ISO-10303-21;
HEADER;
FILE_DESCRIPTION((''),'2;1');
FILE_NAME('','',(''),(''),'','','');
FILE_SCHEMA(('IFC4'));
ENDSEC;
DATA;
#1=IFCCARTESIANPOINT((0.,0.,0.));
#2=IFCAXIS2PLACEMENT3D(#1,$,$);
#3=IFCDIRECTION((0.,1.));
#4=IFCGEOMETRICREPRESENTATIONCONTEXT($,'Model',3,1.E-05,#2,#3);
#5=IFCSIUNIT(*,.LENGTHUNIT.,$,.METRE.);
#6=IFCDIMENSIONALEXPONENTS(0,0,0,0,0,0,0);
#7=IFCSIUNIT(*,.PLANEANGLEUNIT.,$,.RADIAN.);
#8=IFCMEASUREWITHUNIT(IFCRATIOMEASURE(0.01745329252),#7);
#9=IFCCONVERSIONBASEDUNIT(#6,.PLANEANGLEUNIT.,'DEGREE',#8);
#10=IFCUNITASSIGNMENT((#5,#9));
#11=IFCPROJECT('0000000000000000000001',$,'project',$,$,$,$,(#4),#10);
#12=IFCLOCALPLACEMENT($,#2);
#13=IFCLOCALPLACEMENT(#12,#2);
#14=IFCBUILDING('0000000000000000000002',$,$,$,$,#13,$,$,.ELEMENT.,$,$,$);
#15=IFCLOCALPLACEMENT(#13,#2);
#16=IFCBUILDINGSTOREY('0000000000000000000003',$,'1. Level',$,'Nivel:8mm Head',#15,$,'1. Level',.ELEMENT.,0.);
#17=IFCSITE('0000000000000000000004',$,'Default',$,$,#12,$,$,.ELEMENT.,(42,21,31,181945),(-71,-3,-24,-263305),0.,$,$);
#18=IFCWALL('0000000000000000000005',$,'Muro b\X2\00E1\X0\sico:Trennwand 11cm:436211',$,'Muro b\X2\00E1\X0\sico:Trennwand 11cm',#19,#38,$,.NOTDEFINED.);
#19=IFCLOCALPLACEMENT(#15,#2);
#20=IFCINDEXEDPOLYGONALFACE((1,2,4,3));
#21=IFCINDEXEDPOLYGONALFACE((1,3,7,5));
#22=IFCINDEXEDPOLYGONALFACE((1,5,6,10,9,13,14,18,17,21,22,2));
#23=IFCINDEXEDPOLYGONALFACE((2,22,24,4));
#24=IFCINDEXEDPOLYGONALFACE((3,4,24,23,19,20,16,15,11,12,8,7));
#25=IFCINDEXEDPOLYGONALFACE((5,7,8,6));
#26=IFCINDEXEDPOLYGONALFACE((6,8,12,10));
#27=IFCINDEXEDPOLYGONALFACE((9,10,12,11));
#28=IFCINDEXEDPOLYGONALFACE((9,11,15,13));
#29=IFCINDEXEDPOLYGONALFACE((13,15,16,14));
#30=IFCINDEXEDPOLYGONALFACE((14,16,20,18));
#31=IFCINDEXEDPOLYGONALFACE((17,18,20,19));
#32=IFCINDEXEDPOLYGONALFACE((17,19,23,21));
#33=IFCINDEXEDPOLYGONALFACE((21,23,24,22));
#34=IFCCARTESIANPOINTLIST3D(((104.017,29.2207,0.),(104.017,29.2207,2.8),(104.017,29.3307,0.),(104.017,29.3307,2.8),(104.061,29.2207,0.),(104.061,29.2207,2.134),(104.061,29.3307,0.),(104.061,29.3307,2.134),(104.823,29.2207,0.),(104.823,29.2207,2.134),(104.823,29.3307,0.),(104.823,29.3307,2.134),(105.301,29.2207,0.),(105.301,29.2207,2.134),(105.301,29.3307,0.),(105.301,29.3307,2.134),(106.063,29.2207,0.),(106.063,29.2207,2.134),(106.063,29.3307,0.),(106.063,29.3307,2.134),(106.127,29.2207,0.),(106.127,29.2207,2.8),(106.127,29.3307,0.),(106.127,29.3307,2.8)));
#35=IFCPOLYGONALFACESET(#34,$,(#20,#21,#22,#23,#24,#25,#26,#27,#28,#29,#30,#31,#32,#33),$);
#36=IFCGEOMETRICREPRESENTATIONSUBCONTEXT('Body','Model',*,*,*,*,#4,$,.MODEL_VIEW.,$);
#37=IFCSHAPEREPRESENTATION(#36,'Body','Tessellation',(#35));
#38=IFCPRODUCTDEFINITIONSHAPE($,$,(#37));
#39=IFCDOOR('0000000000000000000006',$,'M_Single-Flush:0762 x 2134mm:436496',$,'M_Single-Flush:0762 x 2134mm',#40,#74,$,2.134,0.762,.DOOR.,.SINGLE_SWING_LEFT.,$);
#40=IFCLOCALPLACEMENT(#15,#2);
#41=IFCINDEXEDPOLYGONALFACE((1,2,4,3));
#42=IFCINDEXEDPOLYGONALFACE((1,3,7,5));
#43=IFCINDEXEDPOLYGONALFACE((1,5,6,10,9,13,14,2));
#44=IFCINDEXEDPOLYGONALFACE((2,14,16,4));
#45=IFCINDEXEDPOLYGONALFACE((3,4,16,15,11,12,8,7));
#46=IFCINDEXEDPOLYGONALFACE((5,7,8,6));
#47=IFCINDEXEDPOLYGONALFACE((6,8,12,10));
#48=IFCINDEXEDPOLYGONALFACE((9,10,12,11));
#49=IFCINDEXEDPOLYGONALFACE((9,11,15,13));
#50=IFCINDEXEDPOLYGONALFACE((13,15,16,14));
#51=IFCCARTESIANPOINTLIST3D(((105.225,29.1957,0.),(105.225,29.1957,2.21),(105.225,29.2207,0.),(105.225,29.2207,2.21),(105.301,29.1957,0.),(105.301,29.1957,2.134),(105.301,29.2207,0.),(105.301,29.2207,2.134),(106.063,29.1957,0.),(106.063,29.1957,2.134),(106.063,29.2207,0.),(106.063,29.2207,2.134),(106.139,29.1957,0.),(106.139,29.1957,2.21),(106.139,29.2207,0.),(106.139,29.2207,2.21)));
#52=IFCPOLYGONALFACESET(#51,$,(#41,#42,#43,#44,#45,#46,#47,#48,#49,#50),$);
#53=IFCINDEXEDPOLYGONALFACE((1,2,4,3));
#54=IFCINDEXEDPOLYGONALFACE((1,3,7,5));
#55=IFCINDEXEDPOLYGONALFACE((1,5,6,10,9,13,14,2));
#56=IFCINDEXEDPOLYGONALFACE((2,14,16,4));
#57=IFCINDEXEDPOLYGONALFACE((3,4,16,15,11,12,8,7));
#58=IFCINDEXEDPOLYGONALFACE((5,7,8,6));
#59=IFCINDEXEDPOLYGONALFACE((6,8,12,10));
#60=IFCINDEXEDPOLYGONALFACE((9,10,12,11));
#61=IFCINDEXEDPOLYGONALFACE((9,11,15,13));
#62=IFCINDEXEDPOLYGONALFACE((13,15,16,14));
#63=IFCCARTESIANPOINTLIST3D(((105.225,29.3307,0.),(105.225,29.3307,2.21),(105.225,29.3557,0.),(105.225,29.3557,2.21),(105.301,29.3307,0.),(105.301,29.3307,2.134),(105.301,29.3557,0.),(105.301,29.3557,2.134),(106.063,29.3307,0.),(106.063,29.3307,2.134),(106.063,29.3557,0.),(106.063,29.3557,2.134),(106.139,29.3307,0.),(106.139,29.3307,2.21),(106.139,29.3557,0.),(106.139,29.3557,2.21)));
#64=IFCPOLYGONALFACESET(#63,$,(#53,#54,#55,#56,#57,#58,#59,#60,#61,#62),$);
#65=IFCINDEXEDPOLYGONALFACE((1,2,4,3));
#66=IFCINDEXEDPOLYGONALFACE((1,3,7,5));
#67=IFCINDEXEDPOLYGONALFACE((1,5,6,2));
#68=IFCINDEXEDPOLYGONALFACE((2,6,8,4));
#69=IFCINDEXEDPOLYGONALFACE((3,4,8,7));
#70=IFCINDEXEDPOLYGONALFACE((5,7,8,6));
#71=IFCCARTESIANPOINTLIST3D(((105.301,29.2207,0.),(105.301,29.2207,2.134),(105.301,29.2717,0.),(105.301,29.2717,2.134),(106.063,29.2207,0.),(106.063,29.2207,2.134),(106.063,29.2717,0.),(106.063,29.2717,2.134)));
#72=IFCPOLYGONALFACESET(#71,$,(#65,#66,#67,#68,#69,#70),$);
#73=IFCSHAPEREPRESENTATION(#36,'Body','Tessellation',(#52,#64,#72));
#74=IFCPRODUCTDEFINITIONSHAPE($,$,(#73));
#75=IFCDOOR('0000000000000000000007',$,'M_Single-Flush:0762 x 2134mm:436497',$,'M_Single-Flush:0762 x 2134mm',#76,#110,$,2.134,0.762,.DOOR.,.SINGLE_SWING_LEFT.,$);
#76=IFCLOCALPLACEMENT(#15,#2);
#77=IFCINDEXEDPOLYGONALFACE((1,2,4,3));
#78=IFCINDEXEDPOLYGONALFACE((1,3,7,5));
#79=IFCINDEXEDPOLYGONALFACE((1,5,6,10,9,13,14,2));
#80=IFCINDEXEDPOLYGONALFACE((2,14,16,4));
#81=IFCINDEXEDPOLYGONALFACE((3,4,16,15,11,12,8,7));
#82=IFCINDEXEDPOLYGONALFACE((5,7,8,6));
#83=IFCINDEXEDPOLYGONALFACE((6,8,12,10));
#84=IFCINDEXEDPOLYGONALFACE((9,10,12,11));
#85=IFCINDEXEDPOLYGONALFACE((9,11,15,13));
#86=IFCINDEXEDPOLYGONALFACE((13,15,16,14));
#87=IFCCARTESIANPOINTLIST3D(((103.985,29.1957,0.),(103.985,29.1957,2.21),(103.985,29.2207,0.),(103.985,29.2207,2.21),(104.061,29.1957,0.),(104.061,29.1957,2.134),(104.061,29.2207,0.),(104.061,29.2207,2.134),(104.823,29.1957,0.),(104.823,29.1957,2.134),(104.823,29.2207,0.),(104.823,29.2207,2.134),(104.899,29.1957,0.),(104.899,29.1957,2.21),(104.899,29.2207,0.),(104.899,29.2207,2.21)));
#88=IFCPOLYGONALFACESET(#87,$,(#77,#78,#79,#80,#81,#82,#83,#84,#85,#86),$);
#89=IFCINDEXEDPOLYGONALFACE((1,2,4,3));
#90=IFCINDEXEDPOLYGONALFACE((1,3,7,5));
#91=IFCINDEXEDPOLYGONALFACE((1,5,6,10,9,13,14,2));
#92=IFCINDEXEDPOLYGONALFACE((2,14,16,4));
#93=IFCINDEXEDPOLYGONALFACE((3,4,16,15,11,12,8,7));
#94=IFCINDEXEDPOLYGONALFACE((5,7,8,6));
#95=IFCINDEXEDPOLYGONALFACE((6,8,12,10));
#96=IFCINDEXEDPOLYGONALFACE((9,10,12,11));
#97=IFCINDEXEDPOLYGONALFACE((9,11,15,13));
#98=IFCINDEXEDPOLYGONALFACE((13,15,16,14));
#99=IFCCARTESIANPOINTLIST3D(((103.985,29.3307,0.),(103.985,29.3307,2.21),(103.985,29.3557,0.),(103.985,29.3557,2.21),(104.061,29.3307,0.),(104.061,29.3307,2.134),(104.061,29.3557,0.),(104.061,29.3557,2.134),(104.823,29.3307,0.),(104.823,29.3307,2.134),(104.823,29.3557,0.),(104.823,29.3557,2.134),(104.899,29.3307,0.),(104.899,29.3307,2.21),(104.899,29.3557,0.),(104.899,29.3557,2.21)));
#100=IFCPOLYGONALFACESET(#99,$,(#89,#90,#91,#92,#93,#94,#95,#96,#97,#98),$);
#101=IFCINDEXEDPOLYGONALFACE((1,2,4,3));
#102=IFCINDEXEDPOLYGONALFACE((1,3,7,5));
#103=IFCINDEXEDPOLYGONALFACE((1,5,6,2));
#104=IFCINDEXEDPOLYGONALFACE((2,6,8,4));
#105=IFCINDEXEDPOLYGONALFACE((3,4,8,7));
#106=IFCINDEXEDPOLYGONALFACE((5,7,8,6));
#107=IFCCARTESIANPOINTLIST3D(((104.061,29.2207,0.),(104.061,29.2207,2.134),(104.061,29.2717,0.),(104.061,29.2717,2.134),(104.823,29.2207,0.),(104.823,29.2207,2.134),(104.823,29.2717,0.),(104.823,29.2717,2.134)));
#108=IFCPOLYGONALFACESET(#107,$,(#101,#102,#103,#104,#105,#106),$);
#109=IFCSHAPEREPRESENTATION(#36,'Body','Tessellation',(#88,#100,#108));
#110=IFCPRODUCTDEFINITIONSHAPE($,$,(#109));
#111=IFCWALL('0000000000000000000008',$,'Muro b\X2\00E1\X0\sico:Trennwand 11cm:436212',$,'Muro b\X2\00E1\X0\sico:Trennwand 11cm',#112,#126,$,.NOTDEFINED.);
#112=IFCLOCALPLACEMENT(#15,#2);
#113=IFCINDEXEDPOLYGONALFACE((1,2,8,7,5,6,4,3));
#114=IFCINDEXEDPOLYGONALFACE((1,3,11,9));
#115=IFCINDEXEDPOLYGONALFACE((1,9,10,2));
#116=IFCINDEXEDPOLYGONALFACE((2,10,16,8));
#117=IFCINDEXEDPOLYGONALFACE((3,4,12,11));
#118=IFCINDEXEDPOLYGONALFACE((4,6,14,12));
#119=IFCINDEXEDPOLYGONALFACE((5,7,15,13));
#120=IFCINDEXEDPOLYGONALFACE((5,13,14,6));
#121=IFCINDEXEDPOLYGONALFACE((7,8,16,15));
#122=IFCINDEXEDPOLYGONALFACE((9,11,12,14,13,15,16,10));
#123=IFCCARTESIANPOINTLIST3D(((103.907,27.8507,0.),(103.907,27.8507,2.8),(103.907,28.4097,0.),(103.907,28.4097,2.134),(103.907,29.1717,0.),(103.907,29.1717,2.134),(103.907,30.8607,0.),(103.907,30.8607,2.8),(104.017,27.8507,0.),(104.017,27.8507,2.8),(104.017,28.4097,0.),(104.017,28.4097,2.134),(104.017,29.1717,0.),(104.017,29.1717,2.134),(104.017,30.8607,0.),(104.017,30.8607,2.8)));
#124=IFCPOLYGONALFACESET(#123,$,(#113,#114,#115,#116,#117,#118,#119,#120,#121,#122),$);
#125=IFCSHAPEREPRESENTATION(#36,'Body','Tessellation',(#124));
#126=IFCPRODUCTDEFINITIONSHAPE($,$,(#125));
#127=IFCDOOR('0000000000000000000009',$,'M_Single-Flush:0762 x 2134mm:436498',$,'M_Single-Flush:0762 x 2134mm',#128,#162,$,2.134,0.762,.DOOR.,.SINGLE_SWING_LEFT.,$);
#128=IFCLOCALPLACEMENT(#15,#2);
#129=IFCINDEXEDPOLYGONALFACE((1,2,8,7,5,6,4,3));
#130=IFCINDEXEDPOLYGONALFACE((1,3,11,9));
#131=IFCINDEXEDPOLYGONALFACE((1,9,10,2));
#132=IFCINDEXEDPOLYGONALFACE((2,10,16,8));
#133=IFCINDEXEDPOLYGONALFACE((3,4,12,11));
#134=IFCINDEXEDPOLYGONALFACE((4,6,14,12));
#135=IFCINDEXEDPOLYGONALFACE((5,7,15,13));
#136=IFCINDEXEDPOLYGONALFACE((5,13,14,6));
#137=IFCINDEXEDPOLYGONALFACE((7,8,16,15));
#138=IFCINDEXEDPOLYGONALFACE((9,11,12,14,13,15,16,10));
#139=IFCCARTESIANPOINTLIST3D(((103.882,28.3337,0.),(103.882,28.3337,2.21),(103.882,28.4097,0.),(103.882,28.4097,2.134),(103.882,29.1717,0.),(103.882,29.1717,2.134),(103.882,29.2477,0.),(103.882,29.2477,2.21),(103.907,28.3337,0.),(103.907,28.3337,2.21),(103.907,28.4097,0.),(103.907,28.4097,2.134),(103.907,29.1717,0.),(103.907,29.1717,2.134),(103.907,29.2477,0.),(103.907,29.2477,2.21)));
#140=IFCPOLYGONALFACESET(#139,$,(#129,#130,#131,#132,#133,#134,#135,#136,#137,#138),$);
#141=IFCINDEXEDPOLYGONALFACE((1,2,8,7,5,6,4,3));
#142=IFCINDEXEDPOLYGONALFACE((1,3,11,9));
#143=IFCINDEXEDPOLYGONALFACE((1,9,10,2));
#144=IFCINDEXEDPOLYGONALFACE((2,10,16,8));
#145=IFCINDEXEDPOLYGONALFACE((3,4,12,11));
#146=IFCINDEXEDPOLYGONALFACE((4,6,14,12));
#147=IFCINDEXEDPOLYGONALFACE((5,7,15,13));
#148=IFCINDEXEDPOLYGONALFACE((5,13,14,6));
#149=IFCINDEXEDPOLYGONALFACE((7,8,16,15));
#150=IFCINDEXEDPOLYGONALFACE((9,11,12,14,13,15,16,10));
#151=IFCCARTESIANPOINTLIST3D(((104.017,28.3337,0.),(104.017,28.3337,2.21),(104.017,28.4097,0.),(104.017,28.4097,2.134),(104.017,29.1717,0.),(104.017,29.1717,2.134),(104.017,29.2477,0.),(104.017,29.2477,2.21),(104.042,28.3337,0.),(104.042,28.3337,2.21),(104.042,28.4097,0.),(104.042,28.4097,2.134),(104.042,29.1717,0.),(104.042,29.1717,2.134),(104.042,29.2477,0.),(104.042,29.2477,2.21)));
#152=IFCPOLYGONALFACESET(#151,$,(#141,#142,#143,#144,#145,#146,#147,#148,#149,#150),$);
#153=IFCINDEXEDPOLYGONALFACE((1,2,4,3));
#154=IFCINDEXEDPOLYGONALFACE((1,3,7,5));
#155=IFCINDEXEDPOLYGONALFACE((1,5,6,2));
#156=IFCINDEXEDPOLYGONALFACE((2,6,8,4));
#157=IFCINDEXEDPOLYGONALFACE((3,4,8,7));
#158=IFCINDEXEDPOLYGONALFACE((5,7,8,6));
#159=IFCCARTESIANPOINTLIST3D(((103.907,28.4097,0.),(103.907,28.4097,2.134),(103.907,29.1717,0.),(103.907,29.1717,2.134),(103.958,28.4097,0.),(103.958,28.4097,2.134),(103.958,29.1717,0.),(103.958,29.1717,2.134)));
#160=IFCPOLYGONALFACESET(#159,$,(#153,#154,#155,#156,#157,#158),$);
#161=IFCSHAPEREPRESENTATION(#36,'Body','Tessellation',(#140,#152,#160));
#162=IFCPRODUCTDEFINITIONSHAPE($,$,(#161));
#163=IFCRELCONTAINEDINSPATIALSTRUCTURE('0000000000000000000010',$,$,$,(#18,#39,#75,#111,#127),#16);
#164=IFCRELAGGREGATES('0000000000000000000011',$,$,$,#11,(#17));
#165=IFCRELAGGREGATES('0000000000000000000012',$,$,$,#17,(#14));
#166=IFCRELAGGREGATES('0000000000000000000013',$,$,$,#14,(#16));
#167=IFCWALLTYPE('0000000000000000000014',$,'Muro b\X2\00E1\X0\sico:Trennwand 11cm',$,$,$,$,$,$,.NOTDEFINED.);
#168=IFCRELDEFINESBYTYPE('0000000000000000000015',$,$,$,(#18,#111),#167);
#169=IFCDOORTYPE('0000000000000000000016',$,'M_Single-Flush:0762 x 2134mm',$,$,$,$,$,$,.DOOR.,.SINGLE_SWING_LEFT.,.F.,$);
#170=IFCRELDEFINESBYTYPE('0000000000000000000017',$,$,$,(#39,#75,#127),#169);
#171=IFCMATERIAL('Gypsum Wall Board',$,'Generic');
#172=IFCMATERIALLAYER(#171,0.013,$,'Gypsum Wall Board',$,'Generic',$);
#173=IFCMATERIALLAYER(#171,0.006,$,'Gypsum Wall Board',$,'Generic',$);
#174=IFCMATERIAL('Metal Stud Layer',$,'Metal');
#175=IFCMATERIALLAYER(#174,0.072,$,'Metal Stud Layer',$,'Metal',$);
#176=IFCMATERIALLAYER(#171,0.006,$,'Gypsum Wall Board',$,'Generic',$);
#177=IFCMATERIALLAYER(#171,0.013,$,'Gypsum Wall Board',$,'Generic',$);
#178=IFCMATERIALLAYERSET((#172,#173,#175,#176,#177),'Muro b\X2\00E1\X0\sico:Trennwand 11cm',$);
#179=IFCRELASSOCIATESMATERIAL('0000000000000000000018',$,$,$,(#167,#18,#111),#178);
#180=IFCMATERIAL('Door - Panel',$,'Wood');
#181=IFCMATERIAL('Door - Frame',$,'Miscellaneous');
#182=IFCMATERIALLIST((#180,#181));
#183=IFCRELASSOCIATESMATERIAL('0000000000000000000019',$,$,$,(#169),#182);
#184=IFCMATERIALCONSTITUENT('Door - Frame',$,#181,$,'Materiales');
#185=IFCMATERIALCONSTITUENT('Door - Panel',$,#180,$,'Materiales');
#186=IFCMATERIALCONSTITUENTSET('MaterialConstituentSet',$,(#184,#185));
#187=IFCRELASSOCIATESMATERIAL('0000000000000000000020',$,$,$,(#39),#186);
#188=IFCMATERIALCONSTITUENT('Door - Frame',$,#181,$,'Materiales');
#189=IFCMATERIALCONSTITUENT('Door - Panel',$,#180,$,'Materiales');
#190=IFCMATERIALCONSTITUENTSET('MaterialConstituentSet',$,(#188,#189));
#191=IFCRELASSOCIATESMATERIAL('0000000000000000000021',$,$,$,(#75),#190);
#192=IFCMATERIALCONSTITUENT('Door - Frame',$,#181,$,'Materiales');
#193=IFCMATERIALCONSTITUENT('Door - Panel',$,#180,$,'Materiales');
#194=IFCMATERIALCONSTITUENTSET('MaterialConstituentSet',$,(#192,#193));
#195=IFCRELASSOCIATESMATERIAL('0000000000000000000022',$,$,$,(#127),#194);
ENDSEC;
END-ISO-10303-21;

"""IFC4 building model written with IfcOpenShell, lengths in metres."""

from ifc_helpers import new_model, entity, si_unit, converted_unit, direction, frame, frame_2d, origin, origin_2d_with_axis, place, context, subcontext, project, spatial, polyline, rectangle, outline, extrude, source, transform, mapped, material, material_list, layer, layer_set, layer_usage, constituent, constituent_set, type_object, type_shapes, element, fill, save


model = new_model("IFC4")

# Units and contexts
model_context = context("Model", 3, precision=1e-05, world=origin(), true_north=direction((0.0, 1.0)))
body_context = subcontext(model_context, "Body", "Model", "MODEL_VIEW")
ifc_project = project(units=[si_unit("LENGTHUNIT", "METRE"), converted_unit("PLANEANGLEUNIT", "DEGREE", entity("IfcRatioMeasure", 0.01745329252), si_unit("PLANEANGLEUNIT", "RADIAN"), dimensions=[0, 0, 0, 0, 0, 0, 0])], contexts=[model_context])

# Site, building, storey
site_placement = place(None, origin())
site = spatial("IfcSite", under=ifc_project, at=site_placement, Name="Default", CompositionType="ELEMENT", RefLatitude=(42, 21, 31, 181945), RefLongitude=(-71, -3, -24, -263305), RefElevation=0.0)
building_placement = place(site_placement, origin())
building = spatial("IfcBuilding", under=site, at=building_placement, CompositionType="ELEMENT")
storey_placement = place(building_placement, origin())
storey = spatial("IfcBuildingStorey", under=building, at=storey_placement, Name="1. Level", ObjectType="Nivel:8mm Head", LongName="1. Level", CompositionType="ELEMENT", Elevation=0.0)

# Shared definitions
ifc_material_1 = material(Name="Gypsum Wall Board", Category="Generic")
ifc_layer_1 = layer(ifc_material_1, 0.013, Name="Gypsum Wall Board", Category="Generic")
ifc_layer_2 = layer(ifc_material_1, 0.006, Name="Gypsum Wall Board", Category="Generic")
ifc_material_2 = material(Name="Metal Stud Layer", Category="Metal")
ifc_layer_3 = layer(ifc_material_2, 0.072, Name="Metal Stud Layer", Category="Metal")
ifc_layer_4 = layer(ifc_material_1, 0.006, Name="Gypsum Wall Board", Category="Generic")
ifc_layer_5 = layer(ifc_material_1, 0.013, Name="Gypsum Wall Board", Category="Generic")
ifc_layer_set_1 = layer_set([ifc_layer_1, ifc_layer_2, ifc_layer_3, ifc_layer_4, ifc_layer_5], Name="Muro básico:Trennwand 11cm")
wall_type_1 = type_object("IfcWallType", Name="Muro básico:Trennwand 11cm", PredefinedType="NOTDEFINED", material=ifc_layer_set_1)
ifc_material_3 = material(Name="Door - Frame", Category="Miscellaneous")
ifc_material_4 = material(Name="Door - Panel", Category="Wood")
ifc_material_list_1 = material_list([ifc_material_4, ifc_material_3])
door_type_1 = type_object("IfcDoorType", Name="M_Single-Flush:0762 x 2134mm", OperationType="SINGLE_SWING_LEFT", ParameterTakesPrecedence=False, PredefinedType="DOOR", material=ifc_material_list_1)
shared_shape_1 = source(origin(), body_context, "Body", "SweptSolid", [
    extrude(outline(polyline([(-0.457, -1.124), (0.457, -1.124), (0.457, 1.086), (0.381, 1.086), (0.381, -1.048), (-0.381, -1.048), (-0.381, 1.086), (-0.457, 1.086), (-0.457, -1.124)])), frame((0.381, 0.135, 1.086), z_axis=(0.0, -1.0, 0.0), x_axis=(-1.0, 0.0, 0.0)), (0.0, 0.0, 1.0), 0.025),
    extrude(outline(polyline([(-1.124, -0.457), (1.086, -0.457), (1.086, -0.381), (-1.048, -0.381), (-1.048, 0.381), (1.086, 0.381), (1.086, 0.457), (-1.124, 0.457), (-1.124, -0.457)])), frame((0.381, 0.0, 1.086), z_axis=(0.0, -1.0, 0.0), x_axis=(0.0, 0.0, -1.0)), (0.0, 0.0, 1.0), 0.025),
    extrude(rectangle(XDim=0.762, YDim=0.051, at=origin_2d_with_axis()), frame((0.381, 0.0845, 0.0)), (0.0, 0.0, 1.0), 2.134),
])
type_shapes(door_type_1, [shared_shape_1])

# Wall, openings, doors
ifc_layer_usage_1 = layer_usage(ifc_layer_set_1, "AXIS2", "NEGATIVE", 0.055)
wall_1_placement = place(storey_placement, frame((106.127, 29.2757, 0.0), z_axis=(0.0, 0.0, 1.0), x_axis=(-1.0, 0.0, 0.0)))
wall_1 = element("IfcWall", 1, at=wall_1_placement, inside=storey, type_object=wall_type_1, material=ifc_layer_usage_1, Name="Muro básico:Trennwand 11cm:436211", ObjectType="Muro básico:Trennwand 11cm", PredefinedType="NOTDEFINED", context=body_context, shape_type="SweptSolid", body=[
    extrude(rectangle(XDim=2.11, YDim=0.11, at=frame_2d((1.055, 0.0), x_axis=(-1.0, 0.0))), origin(), (0.0, 0.0, 1.0), 2.8),
])
opening_1_placement = place(wall_1_placement, frame((0.064, -0.055, 0.0)))
opening_1 = element("IfcOpeningElement", 2, at=opening_1_placement, cuts=wall_1, ObjectType="Opening", PredefinedType="OPENING", context=body_context, shape_type="SweptSolid", body=[
    extrude(rectangle(XDim=0.762, YDim=2.134, at=frame_2d((1.067, 0.381), x_axis=(0.0, -1.0))), frame((0.0, 0.0, 0.0), z_axis=(0.0, 1.0, 0.0), x_axis=(0.0, 0.0, 1.0)), (0.0, 0.0, 1.0), 0.11),
])
opening_2_placement = place(wall_1_placement, frame((1.304, -0.055, 0.0)))
opening_2 = element("IfcOpeningElement", 3, at=opening_2_placement, cuts=wall_1, ObjectType="Opening", PredefinedType="OPENING", context=body_context, shape_type="SweptSolid", body=[
    extrude(rectangle(XDim=0.762, YDim=2.134, at=frame_2d((1.067, 0.381), x_axis=(0.0, -1.0))), frame((0.0, 0.0, 0.0), z_axis=(0.0, 1.0, 0.0), x_axis=(0.0, 0.0, 1.0)), (0.0, 0.0, 1.0), 0.11),
])
ifc_constituent_1 = constituent(ifc_material_3, Name="Door - Frame", Category="Materiales")
ifc_constituent_2 = constituent(ifc_material_4, Name="Door - Panel", Category="Materiales")
ifc_constituent_set_1 = constituent_set(constituents=[ifc_constituent_1, ifc_constituent_2], Name="MaterialConstituentSet")
door_1_placement = place(opening_1_placement, origin())
door_1 = element("IfcDoor", 4, at=door_1_placement, inside=storey, type_object=door_type_1, material=ifc_constituent_set_1, Name="M_Single-Flush:0762 x 2134mm:436496", ObjectType="M_Single-Flush:0762 x 2134mm", OperationType="SINGLE_SWING_LEFT", OverallHeight=2.134, OverallWidth=0.762, PredefinedType="DOOR", context=body_context, shape_type="MappedRepresentation", body=[
    mapped(shared_shape_1, transform((0.0, 0.0, 0.0), scale=1.0)),
])
fill(opening_1, door_1)
ifc_constituent_3 = constituent(ifc_material_3, Name="Door - Frame", Category="Materiales")
ifc_constituent_4 = constituent(ifc_material_4, Name="Door - Panel", Category="Materiales")
ifc_constituent_set_2 = constituent_set(constituents=[ifc_constituent_3, ifc_constituent_4], Name="MaterialConstituentSet")
door_2_placement = place(opening_2_placement, origin())
door_2 = element("IfcDoor", 5, at=door_2_placement, inside=storey, type_object=door_type_1, material=ifc_constituent_set_2, Name="M_Single-Flush:0762 x 2134mm:436497", ObjectType="M_Single-Flush:0762 x 2134mm", OperationType="SINGLE_SWING_LEFT", OverallHeight=2.134, OverallWidth=0.762, PredefinedType="DOOR", context=body_context, shape_type="MappedRepresentation", body=[
    mapped(shared_shape_1, transform((0.0, 0.0, 0.0), scale=1.0)),
])
fill(opening_2, door_2)

# Wall, opening, door
ifc_layer_usage_2 = layer_usage(ifc_layer_set_1, "AXIS2", "NEGATIVE", 0.055)
wall_2_placement = place(storey_placement, frame((103.962, 30.8607, 0.0), z_axis=(0.0, 0.0, 1.0), x_axis=(0.0, -1.0, 0.0)))
wall_2 = element("IfcWall", 6, at=wall_2_placement, inside=storey, type_object=wall_type_1, material=ifc_layer_usage_2, Name="Muro básico:Trennwand 11cm:436212", ObjectType="Muro básico:Trennwand 11cm", PredefinedType="NOTDEFINED", context=body_context, shape_type="SweptSolid", body=[
    extrude(rectangle(XDim=3.01, YDim=0.11, at=frame_2d((1.505, 0.0), x_axis=(-1.0, 0.0))), origin(), (0.0, 0.0, 1.0), 2.8),
])
opening_3_placement = place(wall_2_placement, frame((2.451, 0.055, 0.0)))
opening_3 = element("IfcOpeningElement", 7, at=opening_3_placement, cuts=wall_2, ObjectType="Opening", PredefinedType="OPENING", context=body_context, shape_type="SweptSolid", body=[
    extrude(rectangle(XDim=0.762, YDim=2.134, at=frame_2d((1.067, 0.381), x_axis=(0.0, -1.0))), frame((0.0, 0.0, 0.0), z_axis=(0.0, -1.0, 0.0), x_axis=(0.0, 0.0, 1.0)), (0.0, 0.0, 1.0), 0.11),
])
ifc_constituent_5 = constituent(ifc_material_3, Name="Door - Frame", Category="Materiales")
ifc_constituent_6 = constituent(ifc_material_4, Name="Door - Panel", Category="Materiales")
ifc_constituent_set_3 = constituent_set(constituents=[ifc_constituent_5, ifc_constituent_6], Name="MaterialConstituentSet")
door_3_placement = place(opening_3_placement, frame((0.0, 0.0, 0.0), z_axis=(0.0, 0.0, 1.0), x_axis=(-1.0, 0.0, 0.0)))
door_3 = element("IfcDoor", 8, at=door_3_placement, inside=storey, type_object=door_type_1, material=ifc_constituent_set_3, Name="M_Single-Flush:0762 x 2134mm:436498", ObjectType="M_Single-Flush:0762 x 2134mm", OperationType="SINGLE_SWING_LEFT", OverallHeight=2.134, OverallWidth=0.762, PredefinedType="DOOR", context=body_context, shape_type="MappedRepresentation", body=[
    mapped(shared_shape_1, transform((0.0, 0.0, 0.0), scale=1.0)),
])
fill(opening_3, door_3)

save(model, "model.ifc")
